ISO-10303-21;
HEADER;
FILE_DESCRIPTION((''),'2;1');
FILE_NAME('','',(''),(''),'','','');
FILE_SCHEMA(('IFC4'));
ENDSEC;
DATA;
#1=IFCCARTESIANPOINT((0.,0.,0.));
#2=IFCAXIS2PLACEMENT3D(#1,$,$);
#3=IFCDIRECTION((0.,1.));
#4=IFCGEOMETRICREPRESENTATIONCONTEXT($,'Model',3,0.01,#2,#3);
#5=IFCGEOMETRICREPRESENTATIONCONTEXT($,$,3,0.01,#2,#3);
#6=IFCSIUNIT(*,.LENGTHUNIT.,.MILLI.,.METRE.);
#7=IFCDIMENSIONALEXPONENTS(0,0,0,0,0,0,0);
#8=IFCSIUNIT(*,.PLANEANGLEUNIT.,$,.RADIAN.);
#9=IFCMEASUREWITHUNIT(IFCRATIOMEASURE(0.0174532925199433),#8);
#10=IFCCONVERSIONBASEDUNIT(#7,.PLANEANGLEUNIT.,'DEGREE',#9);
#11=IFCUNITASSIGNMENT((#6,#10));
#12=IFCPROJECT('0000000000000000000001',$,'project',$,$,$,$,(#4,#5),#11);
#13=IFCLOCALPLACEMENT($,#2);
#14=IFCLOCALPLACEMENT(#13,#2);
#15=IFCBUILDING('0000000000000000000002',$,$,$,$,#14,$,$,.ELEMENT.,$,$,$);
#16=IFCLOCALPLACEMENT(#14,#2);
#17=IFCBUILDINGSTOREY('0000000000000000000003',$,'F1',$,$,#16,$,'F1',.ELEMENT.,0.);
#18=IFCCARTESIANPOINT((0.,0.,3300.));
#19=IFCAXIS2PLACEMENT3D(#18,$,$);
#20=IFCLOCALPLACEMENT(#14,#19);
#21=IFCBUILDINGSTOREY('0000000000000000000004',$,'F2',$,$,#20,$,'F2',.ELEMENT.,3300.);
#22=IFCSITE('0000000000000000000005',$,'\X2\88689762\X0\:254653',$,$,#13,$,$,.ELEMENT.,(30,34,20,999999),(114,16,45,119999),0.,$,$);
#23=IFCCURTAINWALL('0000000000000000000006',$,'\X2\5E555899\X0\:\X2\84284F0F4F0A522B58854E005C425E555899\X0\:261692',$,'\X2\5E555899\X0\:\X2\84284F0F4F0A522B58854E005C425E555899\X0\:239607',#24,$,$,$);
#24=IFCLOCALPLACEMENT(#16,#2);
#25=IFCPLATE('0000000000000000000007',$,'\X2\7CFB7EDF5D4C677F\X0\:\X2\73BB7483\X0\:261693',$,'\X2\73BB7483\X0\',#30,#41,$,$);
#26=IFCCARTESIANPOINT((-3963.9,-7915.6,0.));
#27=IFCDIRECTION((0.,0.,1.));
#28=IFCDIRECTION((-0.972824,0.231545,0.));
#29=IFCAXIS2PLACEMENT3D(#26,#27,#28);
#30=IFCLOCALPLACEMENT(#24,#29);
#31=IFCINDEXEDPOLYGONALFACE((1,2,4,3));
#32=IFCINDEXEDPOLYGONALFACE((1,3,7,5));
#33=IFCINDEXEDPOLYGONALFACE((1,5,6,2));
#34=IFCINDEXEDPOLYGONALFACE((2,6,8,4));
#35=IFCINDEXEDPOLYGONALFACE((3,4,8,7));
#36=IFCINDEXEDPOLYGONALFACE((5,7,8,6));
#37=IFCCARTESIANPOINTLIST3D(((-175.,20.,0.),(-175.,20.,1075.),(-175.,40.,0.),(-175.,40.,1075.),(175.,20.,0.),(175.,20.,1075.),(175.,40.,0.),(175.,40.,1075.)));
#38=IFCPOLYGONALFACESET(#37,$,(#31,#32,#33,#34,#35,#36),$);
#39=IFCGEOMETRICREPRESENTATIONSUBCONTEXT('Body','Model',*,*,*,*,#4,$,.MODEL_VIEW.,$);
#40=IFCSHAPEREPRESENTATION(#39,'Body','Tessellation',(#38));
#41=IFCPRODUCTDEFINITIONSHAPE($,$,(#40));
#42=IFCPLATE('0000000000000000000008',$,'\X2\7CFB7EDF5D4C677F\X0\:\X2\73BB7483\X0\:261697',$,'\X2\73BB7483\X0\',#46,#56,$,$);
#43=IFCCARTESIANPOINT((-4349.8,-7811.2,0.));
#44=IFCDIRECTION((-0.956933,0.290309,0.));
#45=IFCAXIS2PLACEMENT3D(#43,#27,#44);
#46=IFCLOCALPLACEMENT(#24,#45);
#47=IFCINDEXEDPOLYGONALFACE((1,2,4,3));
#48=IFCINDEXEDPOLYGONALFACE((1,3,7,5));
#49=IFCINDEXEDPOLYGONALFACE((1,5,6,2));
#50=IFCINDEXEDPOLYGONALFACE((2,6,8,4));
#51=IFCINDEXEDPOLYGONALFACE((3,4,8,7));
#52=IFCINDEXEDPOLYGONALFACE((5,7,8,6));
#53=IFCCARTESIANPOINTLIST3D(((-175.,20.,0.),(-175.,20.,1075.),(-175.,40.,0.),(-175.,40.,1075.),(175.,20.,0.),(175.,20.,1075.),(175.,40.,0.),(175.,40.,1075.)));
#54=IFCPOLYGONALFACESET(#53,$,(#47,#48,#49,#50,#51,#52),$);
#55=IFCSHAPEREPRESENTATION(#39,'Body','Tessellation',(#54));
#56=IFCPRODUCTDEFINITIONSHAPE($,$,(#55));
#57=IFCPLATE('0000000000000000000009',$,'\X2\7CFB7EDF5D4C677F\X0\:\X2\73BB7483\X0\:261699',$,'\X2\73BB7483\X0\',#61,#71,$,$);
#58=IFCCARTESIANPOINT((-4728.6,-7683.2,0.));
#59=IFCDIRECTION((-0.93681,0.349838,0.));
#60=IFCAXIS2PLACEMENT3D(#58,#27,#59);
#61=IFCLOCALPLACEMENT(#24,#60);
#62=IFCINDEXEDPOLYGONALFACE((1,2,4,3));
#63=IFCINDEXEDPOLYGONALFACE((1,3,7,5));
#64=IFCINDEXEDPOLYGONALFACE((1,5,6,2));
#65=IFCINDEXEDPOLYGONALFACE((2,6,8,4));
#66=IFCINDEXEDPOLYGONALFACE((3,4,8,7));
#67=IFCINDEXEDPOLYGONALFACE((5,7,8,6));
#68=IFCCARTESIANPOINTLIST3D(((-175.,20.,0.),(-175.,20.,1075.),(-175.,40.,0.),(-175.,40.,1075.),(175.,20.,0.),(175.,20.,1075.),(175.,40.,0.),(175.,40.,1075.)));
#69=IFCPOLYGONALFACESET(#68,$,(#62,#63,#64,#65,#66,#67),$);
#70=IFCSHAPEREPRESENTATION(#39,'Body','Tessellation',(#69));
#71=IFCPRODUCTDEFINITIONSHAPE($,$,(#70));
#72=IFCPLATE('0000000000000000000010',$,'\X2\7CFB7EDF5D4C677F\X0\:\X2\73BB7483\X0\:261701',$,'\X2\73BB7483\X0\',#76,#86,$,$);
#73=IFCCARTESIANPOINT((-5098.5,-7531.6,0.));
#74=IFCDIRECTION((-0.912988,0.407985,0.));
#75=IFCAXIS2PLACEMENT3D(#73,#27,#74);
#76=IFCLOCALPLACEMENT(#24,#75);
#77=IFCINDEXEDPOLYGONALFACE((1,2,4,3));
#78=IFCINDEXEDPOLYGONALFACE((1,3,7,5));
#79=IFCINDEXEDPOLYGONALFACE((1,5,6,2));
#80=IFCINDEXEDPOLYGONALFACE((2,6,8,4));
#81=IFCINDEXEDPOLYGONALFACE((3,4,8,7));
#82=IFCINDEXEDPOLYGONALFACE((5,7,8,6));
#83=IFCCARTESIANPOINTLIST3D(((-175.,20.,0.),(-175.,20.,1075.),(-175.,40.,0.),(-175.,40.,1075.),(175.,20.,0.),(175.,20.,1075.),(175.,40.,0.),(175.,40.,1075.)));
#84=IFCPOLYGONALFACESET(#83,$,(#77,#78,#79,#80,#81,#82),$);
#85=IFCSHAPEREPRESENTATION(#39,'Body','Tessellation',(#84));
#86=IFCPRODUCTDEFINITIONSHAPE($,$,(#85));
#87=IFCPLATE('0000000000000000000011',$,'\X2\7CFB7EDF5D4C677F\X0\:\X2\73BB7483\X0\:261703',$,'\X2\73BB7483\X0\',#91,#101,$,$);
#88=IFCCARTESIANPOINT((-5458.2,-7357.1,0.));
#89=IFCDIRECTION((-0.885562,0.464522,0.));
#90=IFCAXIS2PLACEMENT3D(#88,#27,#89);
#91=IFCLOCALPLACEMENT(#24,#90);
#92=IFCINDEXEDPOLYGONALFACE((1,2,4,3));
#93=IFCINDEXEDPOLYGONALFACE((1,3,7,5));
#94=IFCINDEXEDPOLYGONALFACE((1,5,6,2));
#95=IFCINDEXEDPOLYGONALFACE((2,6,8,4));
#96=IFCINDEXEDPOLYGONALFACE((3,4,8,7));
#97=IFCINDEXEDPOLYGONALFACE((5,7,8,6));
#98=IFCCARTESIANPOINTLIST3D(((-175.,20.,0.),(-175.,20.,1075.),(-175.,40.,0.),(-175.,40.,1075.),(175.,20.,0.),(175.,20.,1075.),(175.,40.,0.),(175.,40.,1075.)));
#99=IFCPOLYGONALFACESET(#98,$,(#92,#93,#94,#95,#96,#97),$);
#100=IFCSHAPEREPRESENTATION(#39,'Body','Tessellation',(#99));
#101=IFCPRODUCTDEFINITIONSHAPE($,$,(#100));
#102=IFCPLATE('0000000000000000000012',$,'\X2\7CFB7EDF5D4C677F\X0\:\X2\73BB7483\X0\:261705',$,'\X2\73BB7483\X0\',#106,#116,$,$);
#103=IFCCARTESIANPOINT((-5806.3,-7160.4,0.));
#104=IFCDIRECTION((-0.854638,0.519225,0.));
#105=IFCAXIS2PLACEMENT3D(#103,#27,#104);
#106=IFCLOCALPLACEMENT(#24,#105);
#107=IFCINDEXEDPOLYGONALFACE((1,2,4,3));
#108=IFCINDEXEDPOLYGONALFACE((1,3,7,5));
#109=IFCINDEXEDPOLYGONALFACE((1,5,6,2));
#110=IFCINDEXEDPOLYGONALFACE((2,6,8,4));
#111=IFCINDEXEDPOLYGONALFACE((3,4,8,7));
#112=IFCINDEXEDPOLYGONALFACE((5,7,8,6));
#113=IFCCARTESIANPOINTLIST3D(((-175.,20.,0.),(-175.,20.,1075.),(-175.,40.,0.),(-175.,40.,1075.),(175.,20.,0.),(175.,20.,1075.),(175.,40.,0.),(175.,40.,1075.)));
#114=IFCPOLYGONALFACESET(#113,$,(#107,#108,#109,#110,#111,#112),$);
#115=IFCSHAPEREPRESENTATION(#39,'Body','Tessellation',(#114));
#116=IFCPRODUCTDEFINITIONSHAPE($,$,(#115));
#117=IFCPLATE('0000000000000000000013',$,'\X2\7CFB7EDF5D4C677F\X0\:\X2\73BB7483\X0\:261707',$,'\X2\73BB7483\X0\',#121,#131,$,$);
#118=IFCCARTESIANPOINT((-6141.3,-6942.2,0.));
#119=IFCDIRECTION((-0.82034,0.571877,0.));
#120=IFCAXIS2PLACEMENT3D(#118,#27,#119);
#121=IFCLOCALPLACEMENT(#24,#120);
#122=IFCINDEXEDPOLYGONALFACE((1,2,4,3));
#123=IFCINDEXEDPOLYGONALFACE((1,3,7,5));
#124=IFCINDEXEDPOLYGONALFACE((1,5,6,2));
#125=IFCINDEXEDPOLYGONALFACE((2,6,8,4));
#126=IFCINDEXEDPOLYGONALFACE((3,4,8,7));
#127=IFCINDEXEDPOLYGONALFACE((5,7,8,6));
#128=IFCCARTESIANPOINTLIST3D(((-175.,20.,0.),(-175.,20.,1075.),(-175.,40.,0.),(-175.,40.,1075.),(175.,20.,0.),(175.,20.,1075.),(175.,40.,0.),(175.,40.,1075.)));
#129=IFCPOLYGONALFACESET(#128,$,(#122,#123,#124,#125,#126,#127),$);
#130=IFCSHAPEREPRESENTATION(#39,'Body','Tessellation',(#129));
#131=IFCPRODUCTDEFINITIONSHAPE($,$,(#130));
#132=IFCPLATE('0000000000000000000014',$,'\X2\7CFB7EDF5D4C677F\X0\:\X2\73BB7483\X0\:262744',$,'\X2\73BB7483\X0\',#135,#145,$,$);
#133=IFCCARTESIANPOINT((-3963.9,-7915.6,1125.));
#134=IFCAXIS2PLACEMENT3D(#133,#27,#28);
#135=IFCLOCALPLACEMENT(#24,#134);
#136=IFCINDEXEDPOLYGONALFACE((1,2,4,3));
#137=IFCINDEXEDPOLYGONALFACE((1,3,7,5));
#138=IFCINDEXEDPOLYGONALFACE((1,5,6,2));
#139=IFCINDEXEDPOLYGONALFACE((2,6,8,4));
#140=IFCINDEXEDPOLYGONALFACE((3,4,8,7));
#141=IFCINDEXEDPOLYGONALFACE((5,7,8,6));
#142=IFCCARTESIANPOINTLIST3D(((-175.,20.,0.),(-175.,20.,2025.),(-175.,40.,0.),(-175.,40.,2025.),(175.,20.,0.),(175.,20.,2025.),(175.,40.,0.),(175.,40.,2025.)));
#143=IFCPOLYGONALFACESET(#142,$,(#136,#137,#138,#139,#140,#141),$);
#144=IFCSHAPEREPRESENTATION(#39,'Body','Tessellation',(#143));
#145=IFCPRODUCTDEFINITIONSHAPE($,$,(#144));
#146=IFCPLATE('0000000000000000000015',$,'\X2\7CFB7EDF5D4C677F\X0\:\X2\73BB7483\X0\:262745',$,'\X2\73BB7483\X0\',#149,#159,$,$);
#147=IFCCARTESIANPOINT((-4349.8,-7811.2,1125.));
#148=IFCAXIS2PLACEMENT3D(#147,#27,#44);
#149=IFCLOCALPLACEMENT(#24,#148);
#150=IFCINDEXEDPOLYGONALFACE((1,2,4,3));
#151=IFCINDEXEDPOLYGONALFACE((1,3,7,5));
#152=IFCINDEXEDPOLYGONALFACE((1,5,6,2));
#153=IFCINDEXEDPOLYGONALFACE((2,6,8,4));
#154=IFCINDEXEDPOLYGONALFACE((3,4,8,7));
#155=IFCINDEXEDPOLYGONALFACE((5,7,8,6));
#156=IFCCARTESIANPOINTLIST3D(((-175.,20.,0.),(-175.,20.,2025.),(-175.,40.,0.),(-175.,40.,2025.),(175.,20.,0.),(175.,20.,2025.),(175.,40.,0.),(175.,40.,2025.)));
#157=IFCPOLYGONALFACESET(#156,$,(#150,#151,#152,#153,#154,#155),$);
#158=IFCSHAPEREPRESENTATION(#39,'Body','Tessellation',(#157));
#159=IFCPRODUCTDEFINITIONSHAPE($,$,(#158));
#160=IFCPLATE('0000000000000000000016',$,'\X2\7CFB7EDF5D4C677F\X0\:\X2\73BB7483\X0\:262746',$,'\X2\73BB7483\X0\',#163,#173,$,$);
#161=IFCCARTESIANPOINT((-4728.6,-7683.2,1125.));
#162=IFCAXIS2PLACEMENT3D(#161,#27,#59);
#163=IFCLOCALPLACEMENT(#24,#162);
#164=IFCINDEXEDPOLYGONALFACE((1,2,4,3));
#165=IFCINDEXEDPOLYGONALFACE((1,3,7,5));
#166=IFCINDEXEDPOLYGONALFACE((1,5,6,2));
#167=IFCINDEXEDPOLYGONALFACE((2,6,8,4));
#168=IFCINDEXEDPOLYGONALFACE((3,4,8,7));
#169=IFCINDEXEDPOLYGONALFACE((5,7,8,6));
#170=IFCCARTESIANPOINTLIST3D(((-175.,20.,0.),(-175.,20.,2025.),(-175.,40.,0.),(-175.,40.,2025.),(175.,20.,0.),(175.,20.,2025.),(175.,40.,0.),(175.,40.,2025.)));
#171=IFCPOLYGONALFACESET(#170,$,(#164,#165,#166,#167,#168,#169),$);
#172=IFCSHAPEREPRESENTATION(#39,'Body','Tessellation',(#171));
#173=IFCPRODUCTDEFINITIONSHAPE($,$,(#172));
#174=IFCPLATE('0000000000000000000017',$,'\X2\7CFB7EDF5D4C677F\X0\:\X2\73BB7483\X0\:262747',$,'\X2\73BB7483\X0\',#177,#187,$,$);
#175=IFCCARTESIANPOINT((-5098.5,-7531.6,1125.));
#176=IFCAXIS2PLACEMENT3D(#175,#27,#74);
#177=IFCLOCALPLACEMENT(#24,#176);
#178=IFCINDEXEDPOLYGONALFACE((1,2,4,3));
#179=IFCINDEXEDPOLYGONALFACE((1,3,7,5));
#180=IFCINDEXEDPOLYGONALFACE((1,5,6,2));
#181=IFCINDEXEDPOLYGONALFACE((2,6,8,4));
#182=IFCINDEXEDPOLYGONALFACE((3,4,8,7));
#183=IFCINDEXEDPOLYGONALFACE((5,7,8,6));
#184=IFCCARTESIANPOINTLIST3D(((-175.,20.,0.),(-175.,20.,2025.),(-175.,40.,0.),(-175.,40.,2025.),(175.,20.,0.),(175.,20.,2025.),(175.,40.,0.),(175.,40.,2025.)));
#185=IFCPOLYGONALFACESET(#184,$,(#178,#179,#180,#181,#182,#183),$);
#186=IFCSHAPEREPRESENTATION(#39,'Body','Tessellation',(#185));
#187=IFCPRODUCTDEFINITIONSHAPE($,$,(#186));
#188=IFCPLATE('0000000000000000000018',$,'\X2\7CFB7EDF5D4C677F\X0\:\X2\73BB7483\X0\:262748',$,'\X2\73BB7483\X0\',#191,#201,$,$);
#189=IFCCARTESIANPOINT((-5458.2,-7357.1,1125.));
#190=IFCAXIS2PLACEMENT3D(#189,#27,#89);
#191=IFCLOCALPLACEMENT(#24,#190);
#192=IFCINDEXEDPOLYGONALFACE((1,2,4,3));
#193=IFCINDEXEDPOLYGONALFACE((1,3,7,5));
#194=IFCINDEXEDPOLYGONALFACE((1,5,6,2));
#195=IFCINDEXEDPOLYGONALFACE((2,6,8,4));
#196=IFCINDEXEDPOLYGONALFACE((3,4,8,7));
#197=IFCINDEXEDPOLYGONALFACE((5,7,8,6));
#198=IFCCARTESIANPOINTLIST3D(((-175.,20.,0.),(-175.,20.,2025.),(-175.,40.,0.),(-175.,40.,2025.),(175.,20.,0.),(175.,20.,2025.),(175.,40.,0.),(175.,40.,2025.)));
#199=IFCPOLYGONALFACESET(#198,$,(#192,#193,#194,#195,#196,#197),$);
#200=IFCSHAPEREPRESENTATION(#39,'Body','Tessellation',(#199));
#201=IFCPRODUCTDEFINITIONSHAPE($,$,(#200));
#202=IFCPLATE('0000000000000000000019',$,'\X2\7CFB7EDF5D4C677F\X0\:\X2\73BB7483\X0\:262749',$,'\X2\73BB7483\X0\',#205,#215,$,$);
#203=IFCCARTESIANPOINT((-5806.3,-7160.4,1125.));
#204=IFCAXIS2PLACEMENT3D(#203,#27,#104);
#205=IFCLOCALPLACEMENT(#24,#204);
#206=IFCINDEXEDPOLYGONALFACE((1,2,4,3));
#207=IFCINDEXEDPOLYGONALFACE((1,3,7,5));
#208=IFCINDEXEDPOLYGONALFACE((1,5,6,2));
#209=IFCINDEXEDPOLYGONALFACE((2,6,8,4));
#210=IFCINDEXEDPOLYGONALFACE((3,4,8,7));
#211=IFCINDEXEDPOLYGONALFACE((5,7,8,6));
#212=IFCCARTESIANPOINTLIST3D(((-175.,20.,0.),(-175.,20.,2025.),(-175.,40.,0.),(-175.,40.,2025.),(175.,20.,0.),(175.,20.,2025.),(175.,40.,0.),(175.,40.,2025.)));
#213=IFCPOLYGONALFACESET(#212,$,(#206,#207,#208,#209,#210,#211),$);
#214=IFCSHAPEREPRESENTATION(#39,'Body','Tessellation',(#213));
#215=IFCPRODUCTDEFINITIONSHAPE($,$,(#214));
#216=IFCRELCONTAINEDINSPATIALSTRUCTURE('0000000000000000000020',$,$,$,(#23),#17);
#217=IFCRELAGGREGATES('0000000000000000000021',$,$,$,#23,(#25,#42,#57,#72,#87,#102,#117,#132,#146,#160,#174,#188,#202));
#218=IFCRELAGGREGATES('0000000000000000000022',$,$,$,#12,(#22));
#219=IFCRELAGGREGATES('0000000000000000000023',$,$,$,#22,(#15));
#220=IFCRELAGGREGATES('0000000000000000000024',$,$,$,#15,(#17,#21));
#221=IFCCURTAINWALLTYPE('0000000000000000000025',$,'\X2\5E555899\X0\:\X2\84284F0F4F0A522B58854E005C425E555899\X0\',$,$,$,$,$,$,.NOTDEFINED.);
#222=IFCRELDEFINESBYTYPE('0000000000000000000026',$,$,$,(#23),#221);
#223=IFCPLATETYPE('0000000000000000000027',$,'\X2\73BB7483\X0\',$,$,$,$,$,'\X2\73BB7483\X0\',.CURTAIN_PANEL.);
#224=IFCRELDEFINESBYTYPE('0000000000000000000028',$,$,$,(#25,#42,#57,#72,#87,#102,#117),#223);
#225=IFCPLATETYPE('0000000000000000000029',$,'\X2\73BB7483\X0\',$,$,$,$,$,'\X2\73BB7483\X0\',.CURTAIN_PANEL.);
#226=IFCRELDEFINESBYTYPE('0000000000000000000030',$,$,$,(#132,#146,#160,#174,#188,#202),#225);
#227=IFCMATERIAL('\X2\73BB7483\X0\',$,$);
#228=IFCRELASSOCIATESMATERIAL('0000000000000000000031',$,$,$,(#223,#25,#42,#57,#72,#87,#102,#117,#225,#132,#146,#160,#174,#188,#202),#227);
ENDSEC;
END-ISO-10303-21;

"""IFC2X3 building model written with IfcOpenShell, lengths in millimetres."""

from ifc_helpers import new_model, entity, si_unit, converted_unit, direction, frame, frame_2d, origin, place, context, subcontext, project, spatial, rectangle, extrude, source, transform, mapped, material, type_object, type_shapes, element, aggregate, save


model = new_model("IFC2X3")

# Units and contexts
model_context = context("Model", 3, precision=0.01, world=origin(), true_north=direction((0.0, 1.0)))
context_of_model = context(None, 3, precision=0.01, world=origin(), true_north=direction((0.0, 1.0)))
body_context = subcontext(model_context, "Body", "Model", "MODEL_VIEW")
ifc_project = project(units=[si_unit("LENGTHUNIT", "METRE", prefix="MILLI"), converted_unit("PLANEANGLEUNIT", "DEGREE", entity("IfcRatioMeasure", 0.0174532925199433), si_unit("PLANEANGLEUNIT", "RADIAN"), dimensions=[0, 0, 0, 0, 0, 0, 0])], contexts=[model_context, context_of_model])

# Site, building, storey
site_placement = place(None, origin())
site = spatial("IfcSite", under=ifc_project, at=site_placement, Name="表面:254653", CompositionType="ELEMENT", RefLatitude=(30, 34, 20, 999999), RefLongitude=(114, 16, 45, 119999), RefElevation=0.0)
building_placement = place(site_placement, origin())
building = spatial("IfcBuilding", under=site, at=building_placement, CompositionType="ELEMENT")
storey_1_placement = place(building_placement, origin())
storey_1 = spatial("IfcBuildingStorey", under=building, at=storey_1_placement, Name="F1", LongName="F1", CompositionType="ELEMENT", Elevation=0.0)

# Curtain wall, plates
curtain_wall_type = type_object("IfcCurtainWallType", Name="幕墙:萨伏伊别墅一层幕墙", PredefinedType="NOTDEFINED")
curtain_wall_placement = place(storey_1_placement, origin())
curtain_wall = element("IfcCurtainWall", 1, at=curtain_wall_placement, inside=storey_1, type_object=curtain_wall_type, Name="幕墙:萨伏伊别墅一层幕墙:261692", ObjectType="幕墙:萨伏伊别墅一层幕墙:239607")
ifc_material_1 = material(Name="玻璃")
plate_type_1 = type_object("IfcPlateType", Name="玻璃", ElementType="玻璃", PredefinedType="CURTAIN_PANEL", material=ifc_material_1)
shared_shape_1 = source(origin(), body_context, "Body", "SweptSolid", [
    extrude(rectangle(XDim=20.0, YDim=350.0, at=frame_2d((0.0, 0.0), x_axis=(1.0, 0.0))), frame((0.0, 30.0, 0.0), z_axis=(0.0, 0.0, 1.0), x_axis=(0.0, 1.0, 0.0)), (0.0, 0.0, 1.0), 1075.0),
])
type_shapes(plate_type_1, [shared_shape_1])
plate_1_placement = place(curtain_wall_placement, frame((-3963.9, -7915.6, 0.0), z_axis=(0.0, 0.0, 1.0), x_axis=(-0.972824, 0.231545, 0.0)))
plate_1 = element("IfcPlate", 2, at=plate_1_placement, type_object=plate_type_1, material=ifc_material_1, Name="系统嵌板:玻璃:261693", ObjectType="玻璃", context=body_context, shape_type="MappedRepresentation", body=[
    mapped(shared_shape_1, transform((0.0, 0.0, 0.0), scale=1.0)),
])
plate_2_placement = place(curtain_wall_placement, frame((-4349.8, -7811.2, 0.0), z_axis=(0.0, 0.0, 1.0), x_axis=(-0.956933, 0.290309, 0.0)))
plate_2 = element("IfcPlate", 3, at=plate_2_placement, type_object=plate_type_1, material=ifc_material_1, Name="系统嵌板:玻璃:261697", ObjectType="玻璃", context=body_context, shape_type="MappedRepresentation", body=[
    mapped(shared_shape_1, transform((0.0, 0.0, 0.0), scale=1.0)),
])
plate_3_placement = place(curtain_wall_placement, frame((-4728.6, -7683.2, 0.0), z_axis=(0.0, 0.0, 1.0), x_axis=(-0.93681, 0.349838, 0.0)))
plate_3 = element("IfcPlate", 4, at=plate_3_placement, type_object=plate_type_1, material=ifc_material_1, Name="系统嵌板:玻璃:261699", ObjectType="玻璃", context=body_context, shape_type="MappedRepresentation", body=[
    mapped(shared_shape_1, transform((0.0, 0.0, 0.0), scale=1.0)),
])
plate_4_placement = place(curtain_wall_placement, frame((-5098.5, -7531.6, 0.0), z_axis=(0.0, 0.0, 1.0), x_axis=(-0.912988, 0.407985, 0.0)))
plate_4 = element("IfcPlate", 5, at=plate_4_placement, type_object=plate_type_1, material=ifc_material_1, Name="系统嵌板:玻璃:261701", ObjectType="玻璃", context=body_context, shape_type="MappedRepresentation", body=[
    mapped(shared_shape_1, transform((0.0, 0.0, 0.0), scale=1.0)),
])
plate_5_placement = place(curtain_wall_placement, frame((-5458.2, -7357.1, 0.0), z_axis=(0.0, 0.0, 1.0), x_axis=(-0.885562, 0.464522, 0.0)))
plate_5 = element("IfcPlate", 6, at=plate_5_placement, type_object=plate_type_1, material=ifc_material_1, Name="系统嵌板:玻璃:261703", ObjectType="玻璃", context=body_context, shape_type="MappedRepresentation", body=[
    mapped(shared_shape_1, transform((0.0, 0.0, 0.0), scale=1.0)),
])
plate_6_placement = place(curtain_wall_placement, frame((-5806.3, -7160.4, 0.0), z_axis=(0.0, 0.0, 1.0), x_axis=(-0.854638, 0.519225, 0.0)))
plate_6 = element("IfcPlate", 7, at=plate_6_placement, type_object=plate_type_1, material=ifc_material_1, Name="系统嵌板:玻璃:261705", ObjectType="玻璃", context=body_context, shape_type="MappedRepresentation", body=[
    mapped(shared_shape_1, transform((0.0, 0.0, 0.0), scale=1.0)),
])
plate_7_placement = place(curtain_wall_placement, frame((-6141.3, -6942.2, 0.0), z_axis=(0.0, 0.0, 1.0), x_axis=(-0.82034, 0.571877, 0.0)))
plate_7 = element("IfcPlate", 8, at=plate_7_placement, type_object=plate_type_1, material=ifc_material_1, Name="系统嵌板:玻璃:261707", ObjectType="玻璃", context=body_context, shape_type="MappedRepresentation", body=[
    mapped(shared_shape_1, transform((0.0, 0.0, 0.0), scale=1.0)),
])
plate_type_2 = type_object("IfcPlateType", Name="玻璃", ElementType="玻璃", PredefinedType="CURTAIN_PANEL", material=ifc_material_1)
shared_shape_2 = source(origin(), body_context, "Body", "SweptSolid", [
    extrude(rectangle(XDim=20.0, YDim=350.0, at=frame_2d((0.0, 0.0), x_axis=(1.0, 0.0))), frame((0.0, 30.0, 0.0), z_axis=(0.0, 0.0, 1.0), x_axis=(0.0, 1.0, 0.0)), (0.0, 0.0, 1.0), 2025.0),
])
type_shapes(plate_type_2, [shared_shape_2])
plate_8_placement = place(curtain_wall_placement, frame((-3963.9, -7915.6, 1125.0), z_axis=(0.0, 0.0, 1.0), x_axis=(-0.972824, 0.231545, 0.0)))
plate_8 = element("IfcPlate", 9, at=plate_8_placement, type_object=plate_type_2, material=ifc_material_1, Name="系统嵌板:玻璃:262744", ObjectType="玻璃", context=body_context, shape_type="MappedRepresentation", body=[
    mapped(shared_shape_2, transform((0.0, 0.0, 0.0), scale=1.0)),
])
plate_9_placement = place(curtain_wall_placement, frame((-4349.8, -7811.2, 1125.0), z_axis=(0.0, 0.0, 1.0), x_axis=(-0.956933, 0.290309, 0.0)))
plate_9 = element("IfcPlate", 10, at=plate_9_placement, type_object=plate_type_2, material=ifc_material_1, Name="系统嵌板:玻璃:262745", ObjectType="玻璃", context=body_context, shape_type="MappedRepresentation", body=[
    mapped(shared_shape_2, transform((0.0, 0.0, 0.0), scale=1.0)),
])
plate_10_placement = place(curtain_wall_placement, frame((-4728.6, -7683.2, 1125.0), z_axis=(0.0, 0.0, 1.0), x_axis=(-0.93681, 0.349838, 0.0)))
plate_10 = element("IfcPlate", 11, at=plate_10_placement, type_object=plate_type_2, material=ifc_material_1, Name="系统嵌板:玻璃:262746", ObjectType="玻璃", context=body_context, shape_type="MappedRepresentation", body=[
    mapped(shared_shape_2, transform((0.0, 0.0, 0.0), scale=1.0)),
])
plate_11_placement = place(curtain_wall_placement, frame((-5098.5, -7531.6, 1125.0), z_axis=(0.0, 0.0, 1.0), x_axis=(-0.912988, 0.407985, 0.0)))
plate_11 = element("IfcPlate", 12, at=plate_11_placement, type_object=plate_type_2, material=ifc_material_1, Name="系统嵌板:玻璃:262747", ObjectType="玻璃", context=body_context, shape_type="MappedRepresentation", body=[
    mapped(shared_shape_2, transform((0.0, 0.0, 0.0), scale=1.0)),
])
plate_12_placement = place(curtain_wall_placement, frame((-5458.2, -7357.1, 1125.0), z_axis=(0.0, 0.0, 1.0), x_axis=(-0.885562, 0.464522, 0.0)))
plate_12 = element("IfcPlate", 13, at=plate_12_placement, type_object=plate_type_2, material=ifc_material_1, Name="系统嵌板:玻璃:262748", ObjectType="玻璃", context=body_context, shape_type="MappedRepresentation", body=[
    mapped(shared_shape_2, transform((0.0, 0.0, 0.0), scale=1.0)),
])
plate_13_placement = place(curtain_wall_placement, frame((-5806.3, -7160.4, 1125.0), z_axis=(0.0, 0.0, 1.0), x_axis=(-0.854638, 0.519225, 0.0)))
plate_13 = element("IfcPlate", 14, at=plate_13_placement, type_object=plate_type_2, material=ifc_material_1, Name="系统嵌板:玻璃:262749", ObjectType="玻璃", context=body_context, shape_type="MappedRepresentation", body=[
    mapped(shared_shape_2, transform((0.0, 0.0, 0.0), scale=1.0)),
])
aggregate(curtain_wall, [plate_1, plate_2, plate_3, plate_4, plate_5, plate_6, plate_7, plate_8, plate_9, plate_10, plate_11, plate_12, plate_13])

# Shared definitions
storey_2_placement = place(building_placement, frame((0.0, 0.0, 3300.0)))
storey_2 = spatial("IfcBuildingStorey", under=building, at=storey_2_placement, Name="F2", LongName="F2", CompositionType="ELEMENT", Elevation=3300.0)

save(model, "model.ifc")
